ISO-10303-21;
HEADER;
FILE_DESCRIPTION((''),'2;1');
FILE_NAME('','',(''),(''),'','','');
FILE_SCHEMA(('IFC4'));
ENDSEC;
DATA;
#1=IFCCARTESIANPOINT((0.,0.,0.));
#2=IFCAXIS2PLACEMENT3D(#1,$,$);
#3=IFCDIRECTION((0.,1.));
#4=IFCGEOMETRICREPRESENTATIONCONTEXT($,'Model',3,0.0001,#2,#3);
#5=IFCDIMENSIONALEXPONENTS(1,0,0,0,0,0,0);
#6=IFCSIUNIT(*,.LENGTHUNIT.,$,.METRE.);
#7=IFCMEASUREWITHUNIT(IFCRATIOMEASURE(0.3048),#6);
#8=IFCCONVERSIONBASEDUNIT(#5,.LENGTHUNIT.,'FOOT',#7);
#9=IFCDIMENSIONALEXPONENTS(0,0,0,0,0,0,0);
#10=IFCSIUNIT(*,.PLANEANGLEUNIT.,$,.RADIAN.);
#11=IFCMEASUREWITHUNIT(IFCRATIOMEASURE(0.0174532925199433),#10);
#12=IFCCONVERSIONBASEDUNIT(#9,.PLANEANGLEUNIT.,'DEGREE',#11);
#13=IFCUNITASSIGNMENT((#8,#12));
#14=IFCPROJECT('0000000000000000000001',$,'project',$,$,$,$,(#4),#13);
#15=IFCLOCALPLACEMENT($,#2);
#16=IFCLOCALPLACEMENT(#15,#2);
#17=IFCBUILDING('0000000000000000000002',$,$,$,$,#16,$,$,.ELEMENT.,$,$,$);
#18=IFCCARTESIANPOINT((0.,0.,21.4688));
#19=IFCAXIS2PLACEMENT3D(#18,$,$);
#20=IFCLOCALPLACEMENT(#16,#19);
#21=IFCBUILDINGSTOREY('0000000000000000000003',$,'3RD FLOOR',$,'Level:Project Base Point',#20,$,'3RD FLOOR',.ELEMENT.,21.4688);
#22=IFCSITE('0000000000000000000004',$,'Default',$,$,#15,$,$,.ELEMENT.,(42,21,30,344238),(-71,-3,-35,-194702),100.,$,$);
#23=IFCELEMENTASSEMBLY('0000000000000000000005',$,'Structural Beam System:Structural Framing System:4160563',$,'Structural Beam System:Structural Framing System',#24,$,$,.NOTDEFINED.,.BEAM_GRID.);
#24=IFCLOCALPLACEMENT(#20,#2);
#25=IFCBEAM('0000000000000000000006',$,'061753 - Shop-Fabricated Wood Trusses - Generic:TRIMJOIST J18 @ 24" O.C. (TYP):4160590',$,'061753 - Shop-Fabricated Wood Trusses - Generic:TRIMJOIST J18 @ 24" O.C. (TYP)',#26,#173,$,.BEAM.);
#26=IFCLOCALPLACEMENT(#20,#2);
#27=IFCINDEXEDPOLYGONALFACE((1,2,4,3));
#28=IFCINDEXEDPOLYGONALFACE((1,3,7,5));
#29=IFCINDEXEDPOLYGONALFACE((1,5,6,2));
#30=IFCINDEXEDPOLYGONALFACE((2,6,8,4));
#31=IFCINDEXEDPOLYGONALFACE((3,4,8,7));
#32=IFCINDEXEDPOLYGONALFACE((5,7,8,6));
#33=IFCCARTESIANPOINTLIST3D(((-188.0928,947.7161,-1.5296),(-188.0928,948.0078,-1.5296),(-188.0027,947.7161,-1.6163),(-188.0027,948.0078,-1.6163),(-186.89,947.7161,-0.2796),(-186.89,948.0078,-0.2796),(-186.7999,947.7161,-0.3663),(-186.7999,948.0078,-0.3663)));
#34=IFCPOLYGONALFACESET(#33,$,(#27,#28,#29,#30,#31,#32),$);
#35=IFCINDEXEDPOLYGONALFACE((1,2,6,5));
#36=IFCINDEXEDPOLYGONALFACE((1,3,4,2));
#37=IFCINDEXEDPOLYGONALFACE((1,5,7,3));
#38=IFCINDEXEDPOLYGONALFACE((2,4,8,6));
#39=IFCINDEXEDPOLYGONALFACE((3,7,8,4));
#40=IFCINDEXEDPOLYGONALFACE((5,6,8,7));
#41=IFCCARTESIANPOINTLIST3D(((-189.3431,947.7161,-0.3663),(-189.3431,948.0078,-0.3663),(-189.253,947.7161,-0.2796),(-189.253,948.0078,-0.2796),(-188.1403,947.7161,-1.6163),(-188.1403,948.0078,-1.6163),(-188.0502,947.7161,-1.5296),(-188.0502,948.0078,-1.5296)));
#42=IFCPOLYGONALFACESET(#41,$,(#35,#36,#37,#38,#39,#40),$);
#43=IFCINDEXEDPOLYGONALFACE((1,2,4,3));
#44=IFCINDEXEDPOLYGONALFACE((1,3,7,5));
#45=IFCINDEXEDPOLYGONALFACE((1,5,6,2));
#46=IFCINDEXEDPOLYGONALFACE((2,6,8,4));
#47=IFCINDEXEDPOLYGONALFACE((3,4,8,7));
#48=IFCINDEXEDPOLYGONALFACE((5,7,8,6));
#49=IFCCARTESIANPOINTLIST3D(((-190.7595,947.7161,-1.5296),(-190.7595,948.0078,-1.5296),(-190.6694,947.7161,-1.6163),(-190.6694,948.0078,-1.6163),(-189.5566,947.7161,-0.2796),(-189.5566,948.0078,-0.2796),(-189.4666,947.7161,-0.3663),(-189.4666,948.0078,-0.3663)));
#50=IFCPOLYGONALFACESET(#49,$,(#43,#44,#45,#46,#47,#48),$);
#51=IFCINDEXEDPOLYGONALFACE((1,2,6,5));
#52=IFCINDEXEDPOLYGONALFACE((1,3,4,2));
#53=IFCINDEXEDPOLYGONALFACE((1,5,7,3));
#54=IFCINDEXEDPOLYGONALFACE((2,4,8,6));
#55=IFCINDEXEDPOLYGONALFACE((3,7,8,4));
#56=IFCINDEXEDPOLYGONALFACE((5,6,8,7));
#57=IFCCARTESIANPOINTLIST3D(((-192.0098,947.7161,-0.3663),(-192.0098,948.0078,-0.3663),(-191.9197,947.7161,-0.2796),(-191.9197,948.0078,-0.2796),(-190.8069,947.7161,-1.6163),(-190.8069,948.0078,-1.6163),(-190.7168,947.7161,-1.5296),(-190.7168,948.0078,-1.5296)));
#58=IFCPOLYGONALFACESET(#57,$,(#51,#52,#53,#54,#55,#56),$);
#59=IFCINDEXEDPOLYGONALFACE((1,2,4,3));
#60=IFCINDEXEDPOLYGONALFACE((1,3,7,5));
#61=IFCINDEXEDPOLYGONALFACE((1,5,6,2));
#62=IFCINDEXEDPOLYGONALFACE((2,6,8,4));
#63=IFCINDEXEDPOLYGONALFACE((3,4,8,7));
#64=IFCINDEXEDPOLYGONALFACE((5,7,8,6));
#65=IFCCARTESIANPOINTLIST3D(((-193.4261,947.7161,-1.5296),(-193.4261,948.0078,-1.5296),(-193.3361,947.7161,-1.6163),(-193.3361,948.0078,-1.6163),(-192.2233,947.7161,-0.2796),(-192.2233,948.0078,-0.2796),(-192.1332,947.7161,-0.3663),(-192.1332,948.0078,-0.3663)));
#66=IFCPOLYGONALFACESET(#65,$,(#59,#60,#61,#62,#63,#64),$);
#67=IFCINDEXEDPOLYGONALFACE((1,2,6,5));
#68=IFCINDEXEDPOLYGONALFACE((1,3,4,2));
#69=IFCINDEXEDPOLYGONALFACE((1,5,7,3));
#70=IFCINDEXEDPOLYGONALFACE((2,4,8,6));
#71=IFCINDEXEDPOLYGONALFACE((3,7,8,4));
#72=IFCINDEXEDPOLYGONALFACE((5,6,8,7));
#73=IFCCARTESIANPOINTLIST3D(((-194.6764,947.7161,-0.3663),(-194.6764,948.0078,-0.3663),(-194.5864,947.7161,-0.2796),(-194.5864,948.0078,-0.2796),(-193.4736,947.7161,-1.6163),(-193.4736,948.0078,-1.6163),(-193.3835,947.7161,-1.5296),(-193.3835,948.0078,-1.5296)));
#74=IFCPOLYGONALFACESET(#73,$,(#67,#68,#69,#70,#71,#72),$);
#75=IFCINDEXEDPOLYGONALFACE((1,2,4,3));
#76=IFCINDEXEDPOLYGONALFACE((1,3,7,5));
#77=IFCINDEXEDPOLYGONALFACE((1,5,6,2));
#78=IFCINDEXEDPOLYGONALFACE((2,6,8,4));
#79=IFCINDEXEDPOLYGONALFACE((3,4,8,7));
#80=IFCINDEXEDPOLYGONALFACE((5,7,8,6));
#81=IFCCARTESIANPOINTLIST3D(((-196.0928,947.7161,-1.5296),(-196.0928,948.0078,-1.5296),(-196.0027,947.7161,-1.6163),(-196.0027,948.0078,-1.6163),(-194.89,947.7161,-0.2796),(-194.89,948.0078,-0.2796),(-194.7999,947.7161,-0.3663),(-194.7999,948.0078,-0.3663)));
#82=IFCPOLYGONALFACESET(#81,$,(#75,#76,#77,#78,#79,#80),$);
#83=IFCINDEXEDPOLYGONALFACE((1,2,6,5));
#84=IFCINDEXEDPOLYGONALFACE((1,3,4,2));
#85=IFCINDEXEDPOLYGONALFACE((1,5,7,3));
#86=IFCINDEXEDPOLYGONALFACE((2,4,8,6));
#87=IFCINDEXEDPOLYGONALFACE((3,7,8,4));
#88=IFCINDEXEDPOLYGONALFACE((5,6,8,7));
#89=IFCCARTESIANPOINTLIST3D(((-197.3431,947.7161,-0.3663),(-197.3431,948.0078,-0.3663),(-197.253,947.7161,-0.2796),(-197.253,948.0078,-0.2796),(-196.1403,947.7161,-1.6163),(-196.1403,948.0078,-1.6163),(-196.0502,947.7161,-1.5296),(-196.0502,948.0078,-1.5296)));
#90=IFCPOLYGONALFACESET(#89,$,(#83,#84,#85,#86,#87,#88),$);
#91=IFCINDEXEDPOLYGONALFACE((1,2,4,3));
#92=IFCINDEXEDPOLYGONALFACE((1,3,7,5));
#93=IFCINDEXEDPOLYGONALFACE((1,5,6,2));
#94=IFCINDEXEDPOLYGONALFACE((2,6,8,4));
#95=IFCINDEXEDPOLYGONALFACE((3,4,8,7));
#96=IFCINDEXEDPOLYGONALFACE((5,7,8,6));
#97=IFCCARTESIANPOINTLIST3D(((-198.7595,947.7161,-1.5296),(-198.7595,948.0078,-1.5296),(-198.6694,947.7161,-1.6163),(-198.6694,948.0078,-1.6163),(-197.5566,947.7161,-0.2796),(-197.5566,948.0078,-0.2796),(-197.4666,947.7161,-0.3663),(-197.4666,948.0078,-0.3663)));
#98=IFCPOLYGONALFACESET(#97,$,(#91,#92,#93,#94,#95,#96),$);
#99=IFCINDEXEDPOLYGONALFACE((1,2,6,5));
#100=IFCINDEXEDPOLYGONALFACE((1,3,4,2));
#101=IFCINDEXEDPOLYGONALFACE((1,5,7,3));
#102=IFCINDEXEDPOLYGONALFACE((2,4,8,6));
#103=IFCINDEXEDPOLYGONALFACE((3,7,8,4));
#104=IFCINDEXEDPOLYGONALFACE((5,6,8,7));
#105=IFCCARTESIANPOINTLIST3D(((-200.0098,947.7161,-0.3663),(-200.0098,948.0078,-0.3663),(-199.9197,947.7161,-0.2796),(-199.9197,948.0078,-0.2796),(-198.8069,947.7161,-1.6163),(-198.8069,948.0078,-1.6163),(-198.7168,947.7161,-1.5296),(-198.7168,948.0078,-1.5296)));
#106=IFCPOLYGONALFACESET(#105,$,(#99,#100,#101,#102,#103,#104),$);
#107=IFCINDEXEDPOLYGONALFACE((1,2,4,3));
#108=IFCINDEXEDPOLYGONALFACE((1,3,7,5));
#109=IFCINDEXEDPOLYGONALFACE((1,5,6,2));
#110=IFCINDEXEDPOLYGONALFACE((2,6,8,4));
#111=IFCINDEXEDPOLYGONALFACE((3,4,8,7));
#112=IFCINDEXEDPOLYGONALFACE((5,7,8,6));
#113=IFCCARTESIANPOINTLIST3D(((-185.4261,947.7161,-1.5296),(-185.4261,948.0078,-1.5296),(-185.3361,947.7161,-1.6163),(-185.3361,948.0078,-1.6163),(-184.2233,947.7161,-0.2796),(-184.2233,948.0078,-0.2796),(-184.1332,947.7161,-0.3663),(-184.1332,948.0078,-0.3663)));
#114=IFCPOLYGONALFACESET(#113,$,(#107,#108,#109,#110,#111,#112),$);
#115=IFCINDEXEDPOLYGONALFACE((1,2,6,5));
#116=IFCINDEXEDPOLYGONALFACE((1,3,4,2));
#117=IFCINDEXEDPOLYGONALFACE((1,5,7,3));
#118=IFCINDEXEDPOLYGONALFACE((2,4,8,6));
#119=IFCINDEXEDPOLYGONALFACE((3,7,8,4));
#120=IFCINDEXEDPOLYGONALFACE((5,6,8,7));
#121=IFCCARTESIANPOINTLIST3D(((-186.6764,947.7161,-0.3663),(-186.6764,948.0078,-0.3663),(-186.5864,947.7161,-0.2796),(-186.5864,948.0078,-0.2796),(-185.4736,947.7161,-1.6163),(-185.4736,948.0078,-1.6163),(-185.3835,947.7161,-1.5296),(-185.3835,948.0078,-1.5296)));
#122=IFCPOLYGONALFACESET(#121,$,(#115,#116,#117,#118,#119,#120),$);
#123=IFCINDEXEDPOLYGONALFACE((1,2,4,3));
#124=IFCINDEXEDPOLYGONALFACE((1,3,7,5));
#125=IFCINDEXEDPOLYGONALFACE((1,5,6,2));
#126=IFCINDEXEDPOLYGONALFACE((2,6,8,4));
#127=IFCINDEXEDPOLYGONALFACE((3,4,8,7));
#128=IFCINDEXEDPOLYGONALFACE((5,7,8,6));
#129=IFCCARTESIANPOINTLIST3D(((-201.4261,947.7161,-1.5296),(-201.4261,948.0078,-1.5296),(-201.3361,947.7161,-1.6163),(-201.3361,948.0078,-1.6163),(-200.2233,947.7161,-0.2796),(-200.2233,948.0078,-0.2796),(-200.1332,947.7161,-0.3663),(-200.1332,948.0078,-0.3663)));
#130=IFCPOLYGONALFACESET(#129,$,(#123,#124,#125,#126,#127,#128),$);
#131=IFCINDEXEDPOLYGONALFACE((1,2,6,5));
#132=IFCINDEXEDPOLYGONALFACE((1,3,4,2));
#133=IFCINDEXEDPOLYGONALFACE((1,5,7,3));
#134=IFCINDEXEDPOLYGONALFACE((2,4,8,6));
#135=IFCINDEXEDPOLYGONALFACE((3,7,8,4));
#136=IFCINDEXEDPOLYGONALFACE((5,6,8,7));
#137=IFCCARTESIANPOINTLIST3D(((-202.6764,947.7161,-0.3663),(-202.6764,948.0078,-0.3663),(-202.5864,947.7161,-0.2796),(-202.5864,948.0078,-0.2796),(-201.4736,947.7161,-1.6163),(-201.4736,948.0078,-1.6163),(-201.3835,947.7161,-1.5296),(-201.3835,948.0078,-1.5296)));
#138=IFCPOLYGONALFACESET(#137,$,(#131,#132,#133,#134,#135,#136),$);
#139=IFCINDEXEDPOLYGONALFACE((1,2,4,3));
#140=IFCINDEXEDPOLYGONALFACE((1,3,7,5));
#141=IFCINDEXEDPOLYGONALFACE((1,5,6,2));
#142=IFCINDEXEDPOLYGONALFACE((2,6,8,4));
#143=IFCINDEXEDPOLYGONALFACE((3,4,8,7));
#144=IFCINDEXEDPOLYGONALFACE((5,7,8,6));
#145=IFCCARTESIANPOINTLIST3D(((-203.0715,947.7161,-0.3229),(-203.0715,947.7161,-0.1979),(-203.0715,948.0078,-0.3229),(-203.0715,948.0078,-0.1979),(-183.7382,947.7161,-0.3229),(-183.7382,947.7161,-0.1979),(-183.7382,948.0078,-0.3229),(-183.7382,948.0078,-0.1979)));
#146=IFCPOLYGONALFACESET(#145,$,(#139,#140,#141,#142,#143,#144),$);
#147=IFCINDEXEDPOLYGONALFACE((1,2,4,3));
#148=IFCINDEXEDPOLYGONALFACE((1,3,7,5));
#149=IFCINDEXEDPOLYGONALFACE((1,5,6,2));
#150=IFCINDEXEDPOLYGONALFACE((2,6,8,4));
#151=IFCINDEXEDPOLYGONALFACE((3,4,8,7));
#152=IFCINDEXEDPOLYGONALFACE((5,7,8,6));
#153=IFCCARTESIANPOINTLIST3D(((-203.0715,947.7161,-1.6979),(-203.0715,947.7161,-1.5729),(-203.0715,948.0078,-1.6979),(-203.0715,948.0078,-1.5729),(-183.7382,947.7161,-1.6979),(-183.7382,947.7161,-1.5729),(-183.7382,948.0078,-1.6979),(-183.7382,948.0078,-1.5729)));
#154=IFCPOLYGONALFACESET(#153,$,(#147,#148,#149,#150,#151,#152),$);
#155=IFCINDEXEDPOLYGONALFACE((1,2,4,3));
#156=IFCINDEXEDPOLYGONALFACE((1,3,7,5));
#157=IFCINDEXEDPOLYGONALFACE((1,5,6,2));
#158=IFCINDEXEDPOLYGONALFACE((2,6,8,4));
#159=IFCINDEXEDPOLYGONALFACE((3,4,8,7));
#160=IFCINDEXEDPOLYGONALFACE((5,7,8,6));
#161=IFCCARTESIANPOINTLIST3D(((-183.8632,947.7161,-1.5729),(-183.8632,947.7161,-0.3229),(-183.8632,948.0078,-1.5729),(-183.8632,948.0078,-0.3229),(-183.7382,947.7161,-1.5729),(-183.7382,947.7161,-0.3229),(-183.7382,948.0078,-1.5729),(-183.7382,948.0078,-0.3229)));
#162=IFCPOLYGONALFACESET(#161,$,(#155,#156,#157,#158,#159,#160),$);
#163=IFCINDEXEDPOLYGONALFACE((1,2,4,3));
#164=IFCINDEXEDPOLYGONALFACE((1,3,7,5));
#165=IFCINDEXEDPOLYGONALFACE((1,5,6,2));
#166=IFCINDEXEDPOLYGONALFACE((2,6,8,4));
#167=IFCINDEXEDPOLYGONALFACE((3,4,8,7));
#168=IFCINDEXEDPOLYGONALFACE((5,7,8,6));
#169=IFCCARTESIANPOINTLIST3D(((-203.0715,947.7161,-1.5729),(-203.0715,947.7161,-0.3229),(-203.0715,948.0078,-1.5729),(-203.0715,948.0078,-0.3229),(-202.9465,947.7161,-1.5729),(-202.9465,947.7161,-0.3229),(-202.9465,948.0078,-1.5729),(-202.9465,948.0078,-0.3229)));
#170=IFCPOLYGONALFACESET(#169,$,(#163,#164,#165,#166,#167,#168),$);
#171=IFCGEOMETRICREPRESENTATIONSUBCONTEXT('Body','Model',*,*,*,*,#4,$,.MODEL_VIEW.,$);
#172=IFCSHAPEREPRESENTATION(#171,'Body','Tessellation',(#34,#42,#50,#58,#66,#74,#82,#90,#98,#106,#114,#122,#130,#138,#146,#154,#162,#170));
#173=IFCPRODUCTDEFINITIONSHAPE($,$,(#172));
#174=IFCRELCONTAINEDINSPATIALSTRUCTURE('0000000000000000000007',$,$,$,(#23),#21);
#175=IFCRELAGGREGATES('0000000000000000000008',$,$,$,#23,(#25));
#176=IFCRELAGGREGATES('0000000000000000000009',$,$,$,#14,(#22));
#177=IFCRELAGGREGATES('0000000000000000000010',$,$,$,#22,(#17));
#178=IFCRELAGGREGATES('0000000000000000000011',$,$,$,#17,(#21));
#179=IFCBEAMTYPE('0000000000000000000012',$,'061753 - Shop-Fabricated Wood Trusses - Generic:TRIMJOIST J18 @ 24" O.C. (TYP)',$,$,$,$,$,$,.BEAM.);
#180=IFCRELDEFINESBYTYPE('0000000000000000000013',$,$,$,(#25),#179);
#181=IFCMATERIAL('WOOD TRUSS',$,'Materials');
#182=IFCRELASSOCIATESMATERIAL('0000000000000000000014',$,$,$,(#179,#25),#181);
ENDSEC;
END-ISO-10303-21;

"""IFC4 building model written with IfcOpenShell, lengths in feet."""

from ifc_helpers import new_model, entity, si_unit, converted_unit, direction, frame, frame_2d, origin, origin_2d_with_axis, place, context, subcontext, project, spatial, rectangle, extrude, source, transform, mapped, material, material_profile, profile_set, profile_usage, type_object, type_shapes, element, aggregate, save


model = new_model("IFC4")

# Units and contexts
model_context = context("Model", 3, precision=0.0001, world=origin(), true_north=direction((0.0, 1.0)))
body_context = subcontext(model_context, "Body", "Model", "MODEL_VIEW")
ifc_project = project(units=[converted_unit("LENGTHUNIT", "FOOT", entity("IfcRatioMeasure", 0.3048), si_unit("LENGTHUNIT", "METRE"), dimensions=[1, 0, 0, 0, 0, 0, 0]), converted_unit("PLANEANGLEUNIT", "DEGREE", entity("IfcRatioMeasure", 0.0174532925199433), si_unit("PLANEANGLEUNIT", "RADIAN"), dimensions=[0, 0, 0, 0, 0, 0, 0])], contexts=[model_context])

# Site, building, storey
site_placement = place(None, origin())
site = spatial("IfcSite", under=ifc_project, at=site_placement, Name="Default", CompositionType="ELEMENT", RefLatitude=(42, 21, 30, 344238), RefLongitude=(-71, -3, -35, -194702), RefElevation=100.0)
building_placement = place(site_placement, origin())
building = spatial("IfcBuilding", under=site, at=building_placement, CompositionType="ELEMENT")
storey_placement = place(building_placement, frame((0.0, 0.0, 21.4688)))
storey = spatial("IfcBuildingStorey", under=building, at=storey_placement, Name="3RD FLOOR", ObjectType="Level:Project Base Point", LongName="3RD FLOOR", CompositionType="ELEMENT", Elevation=21.4688)

# Element assembly, beam
ifc_material = material(Name="WOOD TRUSS", Category="Materials")
ifc_material_profile_1 = material_profile(ifc_material, rectangle(XDim=1.7347, YDim=0.125, at=frame_2d((0.0, 0.0), x_axis=(1.0, 0.0))), Name="TRIMJOIST J18 @ 24\" O.C. (TYP)")
ifc_material_profile_2 = material_profile(ifc_material, rectangle(XDim=1.7347, YDim=0.125, at=frame_2d((0.0, 0.0), x_axis=(1.0, 0.0))), Name="TRIMJOIST J18 @ 24\" O.C. (TYP)")
ifc_material_profile_3 = material_profile(ifc_material, rectangle(XDim=1.7347, YDim=0.125, at=frame_2d((0.0, 0.0), x_axis=(1.0, 0.0))), Name="TRIMJOIST J18 @ 24\" O.C. (TYP)")
ifc_material_profile_4 = material_profile(ifc_material, rectangle(XDim=1.7347, YDim=0.125, at=frame_2d((0.0, 0.0), x_axis=(1.0, 0.0))), Name="TRIMJOIST J18 @ 24\" O.C. (TYP)")
ifc_material_profile_5 = material_profile(ifc_material, rectangle(XDim=1.7347, YDim=0.125, at=frame_2d((0.0, 0.0), x_axis=(1.0, 0.0))), Name="TRIMJOIST J18 @ 24\" O.C. (TYP)")
ifc_material_profile_6 = material_profile(ifc_material, rectangle(XDim=1.7347, YDim=0.125, at=frame_2d((0.0, 0.0), x_axis=(1.0, 0.0))), Name="TRIMJOIST J18 @ 24\" O.C. (TYP)")
ifc_material_profile_7 = material_profile(ifc_material, rectangle(XDim=1.7347, YDim=0.125, at=frame_2d((0.0, 0.0), x_axis=(1.0, 0.0))), Name="TRIMJOIST J18 @ 24\" O.C. (TYP)")
ifc_material_profile_8 = material_profile(ifc_material, rectangle(XDim=1.7347, YDim=0.125, at=frame_2d((0.0, 0.0), x_axis=(1.0, 0.0))), Name="TRIMJOIST J18 @ 24\" O.C. (TYP)")
ifc_material_profile_9 = material_profile(ifc_material, rectangle(XDim=1.7347, YDim=0.125, at=frame_2d((0.0, 0.0), x_axis=(1.0, 0.0))), Name="TRIMJOIST J18 @ 24\" O.C. (TYP)")
ifc_material_profile_10 = material_profile(ifc_material, rectangle(XDim=1.7347, YDim=0.125, at=origin_2d_with_axis()), Name="TRIMJOIST J18 @ 24\" O.C. (TYP)")
ifc_material_profile_11 = material_profile(ifc_material, rectangle(XDim=0.125, YDim=0.2917, at=origin_2d_with_axis()), Name="TRIMJOIST J18 @ 24\" O.C. (TYP)")
ifc_material_profile_12 = material_profile(ifc_material, rectangle(XDim=0.125, YDim=0.2917, at=origin_2d_with_axis()), Name="TRIMJOIST J18 @ 24\" O.C. (TYP)")
ifc_material_profile_13 = material_profile(ifc_material, rectangle(XDim=1.25, YDim=0.2917, at=origin_2d_with_axis()), Name="TRIMJOIST J18 @ 24\" O.C. (TYP)")
ifc_material_profile_14 = material_profile(ifc_material, rectangle(XDim=1.25, YDim=0.2917, at=origin_2d_with_axis()), Name="TRIMJOIST J18 @ 24\" O.C. (TYP)")
ifc_profile_set = profile_set([ifc_material_profile_1, ifc_material_profile_2, ifc_material_profile_3, ifc_material_profile_4, ifc_material_profile_5, ifc_material_profile_6, ifc_material_profile_7, ifc_material_profile_8, ifc_material_profile_9, ifc_material_profile_10, ifc_material_profile_11, ifc_material_profile_12, ifc_material_profile_13, ifc_material_profile_14], Name="TRIMJOIST J18 @ 24\" O.C. (TYP)")
beam_type_1 = type_object("IfcBeamType", Name="061753 - Shop-Fabricated Wood Trusses - Generic:TRIMJOIST J18 @ 24\" O.C. (TYP)", PredefinedType="BEAM", material=ifc_profile_set)
shared_shape_1 = source(origin(), body_context, "Body", "SweptSolid", [
    extrude(rectangle(XDim=1.7347, YDim=0.125, at=frame_2d((0.0, 0.0), x_axis=(1.0, 0.0))), frame((5.9585, -0.1458, 0.0), z_axis=(0.0, 1.0, 0.0), x_axis=(0.693383, 0.0, 0.720569)), (0.0, 0.0, 1.0), 0.2917),
    extrude(rectangle(XDim=1.7347, YDim=0.125, at=origin_2d_with_axis()), frame((4.7082, -0.1458, 0.0), z_axis=(0.0, 1.0, 0.0), x_axis=(0.693383, 0.0, -0.720569)), (0.0, 0.0, 1.0), 0.2917),
    extrude(rectangle(XDim=1.7347, YDim=0.125, at=frame_2d((0.0, 0.0), x_axis=(1.0, 0.0))), frame((3.2918, -0.1458, 0.0), z_axis=(0.0, 1.0, 0.0), x_axis=(0.693383, 0.0, 0.720569)), (0.0, 0.0, 1.0), 0.2917),
    extrude(rectangle(XDim=1.7347, YDim=0.125, at=frame_2d((0.0, 0.0), x_axis=(1.0, 0.0))), frame((2.0415, -0.1458, 0.0), z_axis=(0.0, 1.0, 0.0), x_axis=(0.693383, 0.0, -0.720569)), (0.0, 0.0, 1.0), 0.2917),
    extrude(rectangle(XDim=1.7347, YDim=0.125, at=frame_2d((0.0, 0.0), x_axis=(1.0, 0.0))), frame((0.6251, -0.1458, 0.0), z_axis=(0.0, 1.0, 0.0), x_axis=(0.693383, 0.0, 0.720569)), (0.0, 0.0, 1.0), 0.2917),
    extrude(rectangle(XDim=1.7347, YDim=0.125, at=frame_2d((0.0, 0.0), x_axis=(1.0, 0.0))), frame((-0.6251, -0.1458, 0.0), z_axis=(0.0, 1.0, 0.0), x_axis=(0.693383, 0.0, -0.720569)), (0.0, 0.0, 1.0), 0.2917),
    extrude(rectangle(XDim=1.7347, YDim=0.125, at=frame_2d((0.0, 0.0), x_axis=(1.0, 0.0))), frame((-2.0415, -0.1458, 0.0), z_axis=(0.0, 1.0, 0.0), x_axis=(0.693383, 0.0, 0.720569)), (0.0, 0.0, 1.0), 0.2917),
    extrude(rectangle(XDim=1.7347, YDim=0.125, at=origin_2d_with_axis()), frame((-3.2918, -0.1458, 0.0), z_axis=(0.0, 1.0, 0.0), x_axis=(0.693383, 0.0, -0.720569)), (0.0, 0.0, 1.0), 0.2917),
    extrude(rectangle(XDim=1.7347, YDim=0.125, at=frame_2d((0.0, 0.0), x_axis=(1.0, 0.0))), frame((-4.7082, -0.1458, 0.0), z_axis=(0.0, 1.0, 0.0), x_axis=(0.693383, 0.0, 0.720569)), (0.0, 0.0, 1.0), 0.2917),
    extrude(rectangle(XDim=1.7347, YDim=0.125, at=frame_2d((0.0, 0.0), x_axis=(1.0, 0.0))), frame((-5.9585, -0.1458, 0.0), z_axis=(0.0, 1.0, 0.0), x_axis=(0.693383, 0.0, -0.720569)), (0.0, 0.0, 1.0), 0.2917),
    extrude(rectangle(XDim=1.7347, YDim=0.125, at=frame_2d((0.0, 0.0), x_axis=(1.0, 0.0))), frame((8.6251, -0.1458, 0.0), z_axis=(0.0, 1.0, 0.0), x_axis=(0.693383, 0.0, 0.720569)), (0.0, 0.0, 1.0), 0.2917),
    extrude(rectangle(XDim=1.7347, YDim=0.125, at=origin_2d_with_axis()), frame((7.3749, -0.1458, 0.0), z_axis=(0.0, 1.0, 0.0), x_axis=(0.693383, 0.0, -0.720569)), (0.0, 0.0, 1.0), 0.2917),
    extrude(rectangle(XDim=1.7347, YDim=0.125, at=frame_2d((0.0, 0.0), x_axis=(1.0, 0.0))), frame((-7.3749, -0.1458, 0.0), z_axis=(0.0, 1.0, 0.0), x_axis=(0.693383, 0.0, 0.720569)), (0.0, 0.0, 1.0), 0.2917),
    extrude(rectangle(XDim=1.7347, YDim=0.125, at=origin_2d_with_axis()), frame((-8.6251, -0.1458, 0.0), z_axis=(0.0, 1.0, 0.0), x_axis=(0.693383, 0.0, -0.720569)), (0.0, 0.0, 1.0), 0.2917),
    extrude(rectangle(XDim=0.125, YDim=0.2917, at=origin_2d_with_axis()), frame((-9.6667, 0.0, 0.6875), z_axis=(1.0, 0.0, 0.0), x_axis=(0.0, 0.0, -1.0)), (0.0, 0.0, 1.0), 19.3333),
    extrude(rectangle(XDim=0.125, YDim=0.2917, at=origin_2d_with_axis()), frame((-9.6667, 0.0, -0.6875), z_axis=(1.0, 0.0, 0.0), x_axis=(0.0, 0.0, -1.0)), (0.0, 0.0, 1.0), 19.3333),
    extrude(rectangle(XDim=1.25, YDim=0.2917, at=origin_2d_with_axis()), frame((9.5417, 0.0, 0.0), z_axis=(1.0, 0.0, 0.0), x_axis=(0.0, 0.0, -1.0)), (0.0, 0.0, 1.0), 0.125),
    extrude(rectangle(XDim=1.25, YDim=0.2917, at=origin_2d_with_axis()), frame((-9.6667, 0.0, 0.0), z_axis=(1.0, 0.0, 0.0), x_axis=(0.0, 0.0, -1.0)), (0.0, 0.0, 1.0), 0.125),
])
type_shapes(beam_type_1, [shared_shape_1])
assembly_1_placement = place(storey_placement, origin())
assembly_1 = element("IfcElementAssembly", 1, at=assembly_1_placement, inside=storey, Name="Structural Beam System:Structural Framing System:4160563", ObjectType="Structural Beam System:Structural Framing System", AssemblyPlace="NOTDEFINED", PredefinedType="BEAM_GRID")
ifc_profile_usage_1 = profile_usage(ifc_profile_set, cardinal=8)
beam_1_placement = place(assembly_1_placement, frame((-193.4048, 947.8619, -0.9479)))
beam_1 = element("IfcBeam", 2, at=beam_1_placement, type_object=beam_type_1, material=ifc_profile_usage_1, Name="061753 - Shop-Fabricated Wood Trusses - Generic:TRIMJOIST J18 @ 24\" O.C. (TYP):4160590", ObjectType="061753 - Shop-Fabricated Wood Trusses - Generic:TRIMJOIST J18 @ 24\" O.C. (TYP)", PredefinedType="BEAM", context=body_context, shape_type="MappedRepresentation", body=[
    mapped(shared_shape_1, transform((0.0, 0.0, 0.0), scale=1.0)),
])
aggregate(assembly_1, [beam_1])

save(model, "model.ifc")
